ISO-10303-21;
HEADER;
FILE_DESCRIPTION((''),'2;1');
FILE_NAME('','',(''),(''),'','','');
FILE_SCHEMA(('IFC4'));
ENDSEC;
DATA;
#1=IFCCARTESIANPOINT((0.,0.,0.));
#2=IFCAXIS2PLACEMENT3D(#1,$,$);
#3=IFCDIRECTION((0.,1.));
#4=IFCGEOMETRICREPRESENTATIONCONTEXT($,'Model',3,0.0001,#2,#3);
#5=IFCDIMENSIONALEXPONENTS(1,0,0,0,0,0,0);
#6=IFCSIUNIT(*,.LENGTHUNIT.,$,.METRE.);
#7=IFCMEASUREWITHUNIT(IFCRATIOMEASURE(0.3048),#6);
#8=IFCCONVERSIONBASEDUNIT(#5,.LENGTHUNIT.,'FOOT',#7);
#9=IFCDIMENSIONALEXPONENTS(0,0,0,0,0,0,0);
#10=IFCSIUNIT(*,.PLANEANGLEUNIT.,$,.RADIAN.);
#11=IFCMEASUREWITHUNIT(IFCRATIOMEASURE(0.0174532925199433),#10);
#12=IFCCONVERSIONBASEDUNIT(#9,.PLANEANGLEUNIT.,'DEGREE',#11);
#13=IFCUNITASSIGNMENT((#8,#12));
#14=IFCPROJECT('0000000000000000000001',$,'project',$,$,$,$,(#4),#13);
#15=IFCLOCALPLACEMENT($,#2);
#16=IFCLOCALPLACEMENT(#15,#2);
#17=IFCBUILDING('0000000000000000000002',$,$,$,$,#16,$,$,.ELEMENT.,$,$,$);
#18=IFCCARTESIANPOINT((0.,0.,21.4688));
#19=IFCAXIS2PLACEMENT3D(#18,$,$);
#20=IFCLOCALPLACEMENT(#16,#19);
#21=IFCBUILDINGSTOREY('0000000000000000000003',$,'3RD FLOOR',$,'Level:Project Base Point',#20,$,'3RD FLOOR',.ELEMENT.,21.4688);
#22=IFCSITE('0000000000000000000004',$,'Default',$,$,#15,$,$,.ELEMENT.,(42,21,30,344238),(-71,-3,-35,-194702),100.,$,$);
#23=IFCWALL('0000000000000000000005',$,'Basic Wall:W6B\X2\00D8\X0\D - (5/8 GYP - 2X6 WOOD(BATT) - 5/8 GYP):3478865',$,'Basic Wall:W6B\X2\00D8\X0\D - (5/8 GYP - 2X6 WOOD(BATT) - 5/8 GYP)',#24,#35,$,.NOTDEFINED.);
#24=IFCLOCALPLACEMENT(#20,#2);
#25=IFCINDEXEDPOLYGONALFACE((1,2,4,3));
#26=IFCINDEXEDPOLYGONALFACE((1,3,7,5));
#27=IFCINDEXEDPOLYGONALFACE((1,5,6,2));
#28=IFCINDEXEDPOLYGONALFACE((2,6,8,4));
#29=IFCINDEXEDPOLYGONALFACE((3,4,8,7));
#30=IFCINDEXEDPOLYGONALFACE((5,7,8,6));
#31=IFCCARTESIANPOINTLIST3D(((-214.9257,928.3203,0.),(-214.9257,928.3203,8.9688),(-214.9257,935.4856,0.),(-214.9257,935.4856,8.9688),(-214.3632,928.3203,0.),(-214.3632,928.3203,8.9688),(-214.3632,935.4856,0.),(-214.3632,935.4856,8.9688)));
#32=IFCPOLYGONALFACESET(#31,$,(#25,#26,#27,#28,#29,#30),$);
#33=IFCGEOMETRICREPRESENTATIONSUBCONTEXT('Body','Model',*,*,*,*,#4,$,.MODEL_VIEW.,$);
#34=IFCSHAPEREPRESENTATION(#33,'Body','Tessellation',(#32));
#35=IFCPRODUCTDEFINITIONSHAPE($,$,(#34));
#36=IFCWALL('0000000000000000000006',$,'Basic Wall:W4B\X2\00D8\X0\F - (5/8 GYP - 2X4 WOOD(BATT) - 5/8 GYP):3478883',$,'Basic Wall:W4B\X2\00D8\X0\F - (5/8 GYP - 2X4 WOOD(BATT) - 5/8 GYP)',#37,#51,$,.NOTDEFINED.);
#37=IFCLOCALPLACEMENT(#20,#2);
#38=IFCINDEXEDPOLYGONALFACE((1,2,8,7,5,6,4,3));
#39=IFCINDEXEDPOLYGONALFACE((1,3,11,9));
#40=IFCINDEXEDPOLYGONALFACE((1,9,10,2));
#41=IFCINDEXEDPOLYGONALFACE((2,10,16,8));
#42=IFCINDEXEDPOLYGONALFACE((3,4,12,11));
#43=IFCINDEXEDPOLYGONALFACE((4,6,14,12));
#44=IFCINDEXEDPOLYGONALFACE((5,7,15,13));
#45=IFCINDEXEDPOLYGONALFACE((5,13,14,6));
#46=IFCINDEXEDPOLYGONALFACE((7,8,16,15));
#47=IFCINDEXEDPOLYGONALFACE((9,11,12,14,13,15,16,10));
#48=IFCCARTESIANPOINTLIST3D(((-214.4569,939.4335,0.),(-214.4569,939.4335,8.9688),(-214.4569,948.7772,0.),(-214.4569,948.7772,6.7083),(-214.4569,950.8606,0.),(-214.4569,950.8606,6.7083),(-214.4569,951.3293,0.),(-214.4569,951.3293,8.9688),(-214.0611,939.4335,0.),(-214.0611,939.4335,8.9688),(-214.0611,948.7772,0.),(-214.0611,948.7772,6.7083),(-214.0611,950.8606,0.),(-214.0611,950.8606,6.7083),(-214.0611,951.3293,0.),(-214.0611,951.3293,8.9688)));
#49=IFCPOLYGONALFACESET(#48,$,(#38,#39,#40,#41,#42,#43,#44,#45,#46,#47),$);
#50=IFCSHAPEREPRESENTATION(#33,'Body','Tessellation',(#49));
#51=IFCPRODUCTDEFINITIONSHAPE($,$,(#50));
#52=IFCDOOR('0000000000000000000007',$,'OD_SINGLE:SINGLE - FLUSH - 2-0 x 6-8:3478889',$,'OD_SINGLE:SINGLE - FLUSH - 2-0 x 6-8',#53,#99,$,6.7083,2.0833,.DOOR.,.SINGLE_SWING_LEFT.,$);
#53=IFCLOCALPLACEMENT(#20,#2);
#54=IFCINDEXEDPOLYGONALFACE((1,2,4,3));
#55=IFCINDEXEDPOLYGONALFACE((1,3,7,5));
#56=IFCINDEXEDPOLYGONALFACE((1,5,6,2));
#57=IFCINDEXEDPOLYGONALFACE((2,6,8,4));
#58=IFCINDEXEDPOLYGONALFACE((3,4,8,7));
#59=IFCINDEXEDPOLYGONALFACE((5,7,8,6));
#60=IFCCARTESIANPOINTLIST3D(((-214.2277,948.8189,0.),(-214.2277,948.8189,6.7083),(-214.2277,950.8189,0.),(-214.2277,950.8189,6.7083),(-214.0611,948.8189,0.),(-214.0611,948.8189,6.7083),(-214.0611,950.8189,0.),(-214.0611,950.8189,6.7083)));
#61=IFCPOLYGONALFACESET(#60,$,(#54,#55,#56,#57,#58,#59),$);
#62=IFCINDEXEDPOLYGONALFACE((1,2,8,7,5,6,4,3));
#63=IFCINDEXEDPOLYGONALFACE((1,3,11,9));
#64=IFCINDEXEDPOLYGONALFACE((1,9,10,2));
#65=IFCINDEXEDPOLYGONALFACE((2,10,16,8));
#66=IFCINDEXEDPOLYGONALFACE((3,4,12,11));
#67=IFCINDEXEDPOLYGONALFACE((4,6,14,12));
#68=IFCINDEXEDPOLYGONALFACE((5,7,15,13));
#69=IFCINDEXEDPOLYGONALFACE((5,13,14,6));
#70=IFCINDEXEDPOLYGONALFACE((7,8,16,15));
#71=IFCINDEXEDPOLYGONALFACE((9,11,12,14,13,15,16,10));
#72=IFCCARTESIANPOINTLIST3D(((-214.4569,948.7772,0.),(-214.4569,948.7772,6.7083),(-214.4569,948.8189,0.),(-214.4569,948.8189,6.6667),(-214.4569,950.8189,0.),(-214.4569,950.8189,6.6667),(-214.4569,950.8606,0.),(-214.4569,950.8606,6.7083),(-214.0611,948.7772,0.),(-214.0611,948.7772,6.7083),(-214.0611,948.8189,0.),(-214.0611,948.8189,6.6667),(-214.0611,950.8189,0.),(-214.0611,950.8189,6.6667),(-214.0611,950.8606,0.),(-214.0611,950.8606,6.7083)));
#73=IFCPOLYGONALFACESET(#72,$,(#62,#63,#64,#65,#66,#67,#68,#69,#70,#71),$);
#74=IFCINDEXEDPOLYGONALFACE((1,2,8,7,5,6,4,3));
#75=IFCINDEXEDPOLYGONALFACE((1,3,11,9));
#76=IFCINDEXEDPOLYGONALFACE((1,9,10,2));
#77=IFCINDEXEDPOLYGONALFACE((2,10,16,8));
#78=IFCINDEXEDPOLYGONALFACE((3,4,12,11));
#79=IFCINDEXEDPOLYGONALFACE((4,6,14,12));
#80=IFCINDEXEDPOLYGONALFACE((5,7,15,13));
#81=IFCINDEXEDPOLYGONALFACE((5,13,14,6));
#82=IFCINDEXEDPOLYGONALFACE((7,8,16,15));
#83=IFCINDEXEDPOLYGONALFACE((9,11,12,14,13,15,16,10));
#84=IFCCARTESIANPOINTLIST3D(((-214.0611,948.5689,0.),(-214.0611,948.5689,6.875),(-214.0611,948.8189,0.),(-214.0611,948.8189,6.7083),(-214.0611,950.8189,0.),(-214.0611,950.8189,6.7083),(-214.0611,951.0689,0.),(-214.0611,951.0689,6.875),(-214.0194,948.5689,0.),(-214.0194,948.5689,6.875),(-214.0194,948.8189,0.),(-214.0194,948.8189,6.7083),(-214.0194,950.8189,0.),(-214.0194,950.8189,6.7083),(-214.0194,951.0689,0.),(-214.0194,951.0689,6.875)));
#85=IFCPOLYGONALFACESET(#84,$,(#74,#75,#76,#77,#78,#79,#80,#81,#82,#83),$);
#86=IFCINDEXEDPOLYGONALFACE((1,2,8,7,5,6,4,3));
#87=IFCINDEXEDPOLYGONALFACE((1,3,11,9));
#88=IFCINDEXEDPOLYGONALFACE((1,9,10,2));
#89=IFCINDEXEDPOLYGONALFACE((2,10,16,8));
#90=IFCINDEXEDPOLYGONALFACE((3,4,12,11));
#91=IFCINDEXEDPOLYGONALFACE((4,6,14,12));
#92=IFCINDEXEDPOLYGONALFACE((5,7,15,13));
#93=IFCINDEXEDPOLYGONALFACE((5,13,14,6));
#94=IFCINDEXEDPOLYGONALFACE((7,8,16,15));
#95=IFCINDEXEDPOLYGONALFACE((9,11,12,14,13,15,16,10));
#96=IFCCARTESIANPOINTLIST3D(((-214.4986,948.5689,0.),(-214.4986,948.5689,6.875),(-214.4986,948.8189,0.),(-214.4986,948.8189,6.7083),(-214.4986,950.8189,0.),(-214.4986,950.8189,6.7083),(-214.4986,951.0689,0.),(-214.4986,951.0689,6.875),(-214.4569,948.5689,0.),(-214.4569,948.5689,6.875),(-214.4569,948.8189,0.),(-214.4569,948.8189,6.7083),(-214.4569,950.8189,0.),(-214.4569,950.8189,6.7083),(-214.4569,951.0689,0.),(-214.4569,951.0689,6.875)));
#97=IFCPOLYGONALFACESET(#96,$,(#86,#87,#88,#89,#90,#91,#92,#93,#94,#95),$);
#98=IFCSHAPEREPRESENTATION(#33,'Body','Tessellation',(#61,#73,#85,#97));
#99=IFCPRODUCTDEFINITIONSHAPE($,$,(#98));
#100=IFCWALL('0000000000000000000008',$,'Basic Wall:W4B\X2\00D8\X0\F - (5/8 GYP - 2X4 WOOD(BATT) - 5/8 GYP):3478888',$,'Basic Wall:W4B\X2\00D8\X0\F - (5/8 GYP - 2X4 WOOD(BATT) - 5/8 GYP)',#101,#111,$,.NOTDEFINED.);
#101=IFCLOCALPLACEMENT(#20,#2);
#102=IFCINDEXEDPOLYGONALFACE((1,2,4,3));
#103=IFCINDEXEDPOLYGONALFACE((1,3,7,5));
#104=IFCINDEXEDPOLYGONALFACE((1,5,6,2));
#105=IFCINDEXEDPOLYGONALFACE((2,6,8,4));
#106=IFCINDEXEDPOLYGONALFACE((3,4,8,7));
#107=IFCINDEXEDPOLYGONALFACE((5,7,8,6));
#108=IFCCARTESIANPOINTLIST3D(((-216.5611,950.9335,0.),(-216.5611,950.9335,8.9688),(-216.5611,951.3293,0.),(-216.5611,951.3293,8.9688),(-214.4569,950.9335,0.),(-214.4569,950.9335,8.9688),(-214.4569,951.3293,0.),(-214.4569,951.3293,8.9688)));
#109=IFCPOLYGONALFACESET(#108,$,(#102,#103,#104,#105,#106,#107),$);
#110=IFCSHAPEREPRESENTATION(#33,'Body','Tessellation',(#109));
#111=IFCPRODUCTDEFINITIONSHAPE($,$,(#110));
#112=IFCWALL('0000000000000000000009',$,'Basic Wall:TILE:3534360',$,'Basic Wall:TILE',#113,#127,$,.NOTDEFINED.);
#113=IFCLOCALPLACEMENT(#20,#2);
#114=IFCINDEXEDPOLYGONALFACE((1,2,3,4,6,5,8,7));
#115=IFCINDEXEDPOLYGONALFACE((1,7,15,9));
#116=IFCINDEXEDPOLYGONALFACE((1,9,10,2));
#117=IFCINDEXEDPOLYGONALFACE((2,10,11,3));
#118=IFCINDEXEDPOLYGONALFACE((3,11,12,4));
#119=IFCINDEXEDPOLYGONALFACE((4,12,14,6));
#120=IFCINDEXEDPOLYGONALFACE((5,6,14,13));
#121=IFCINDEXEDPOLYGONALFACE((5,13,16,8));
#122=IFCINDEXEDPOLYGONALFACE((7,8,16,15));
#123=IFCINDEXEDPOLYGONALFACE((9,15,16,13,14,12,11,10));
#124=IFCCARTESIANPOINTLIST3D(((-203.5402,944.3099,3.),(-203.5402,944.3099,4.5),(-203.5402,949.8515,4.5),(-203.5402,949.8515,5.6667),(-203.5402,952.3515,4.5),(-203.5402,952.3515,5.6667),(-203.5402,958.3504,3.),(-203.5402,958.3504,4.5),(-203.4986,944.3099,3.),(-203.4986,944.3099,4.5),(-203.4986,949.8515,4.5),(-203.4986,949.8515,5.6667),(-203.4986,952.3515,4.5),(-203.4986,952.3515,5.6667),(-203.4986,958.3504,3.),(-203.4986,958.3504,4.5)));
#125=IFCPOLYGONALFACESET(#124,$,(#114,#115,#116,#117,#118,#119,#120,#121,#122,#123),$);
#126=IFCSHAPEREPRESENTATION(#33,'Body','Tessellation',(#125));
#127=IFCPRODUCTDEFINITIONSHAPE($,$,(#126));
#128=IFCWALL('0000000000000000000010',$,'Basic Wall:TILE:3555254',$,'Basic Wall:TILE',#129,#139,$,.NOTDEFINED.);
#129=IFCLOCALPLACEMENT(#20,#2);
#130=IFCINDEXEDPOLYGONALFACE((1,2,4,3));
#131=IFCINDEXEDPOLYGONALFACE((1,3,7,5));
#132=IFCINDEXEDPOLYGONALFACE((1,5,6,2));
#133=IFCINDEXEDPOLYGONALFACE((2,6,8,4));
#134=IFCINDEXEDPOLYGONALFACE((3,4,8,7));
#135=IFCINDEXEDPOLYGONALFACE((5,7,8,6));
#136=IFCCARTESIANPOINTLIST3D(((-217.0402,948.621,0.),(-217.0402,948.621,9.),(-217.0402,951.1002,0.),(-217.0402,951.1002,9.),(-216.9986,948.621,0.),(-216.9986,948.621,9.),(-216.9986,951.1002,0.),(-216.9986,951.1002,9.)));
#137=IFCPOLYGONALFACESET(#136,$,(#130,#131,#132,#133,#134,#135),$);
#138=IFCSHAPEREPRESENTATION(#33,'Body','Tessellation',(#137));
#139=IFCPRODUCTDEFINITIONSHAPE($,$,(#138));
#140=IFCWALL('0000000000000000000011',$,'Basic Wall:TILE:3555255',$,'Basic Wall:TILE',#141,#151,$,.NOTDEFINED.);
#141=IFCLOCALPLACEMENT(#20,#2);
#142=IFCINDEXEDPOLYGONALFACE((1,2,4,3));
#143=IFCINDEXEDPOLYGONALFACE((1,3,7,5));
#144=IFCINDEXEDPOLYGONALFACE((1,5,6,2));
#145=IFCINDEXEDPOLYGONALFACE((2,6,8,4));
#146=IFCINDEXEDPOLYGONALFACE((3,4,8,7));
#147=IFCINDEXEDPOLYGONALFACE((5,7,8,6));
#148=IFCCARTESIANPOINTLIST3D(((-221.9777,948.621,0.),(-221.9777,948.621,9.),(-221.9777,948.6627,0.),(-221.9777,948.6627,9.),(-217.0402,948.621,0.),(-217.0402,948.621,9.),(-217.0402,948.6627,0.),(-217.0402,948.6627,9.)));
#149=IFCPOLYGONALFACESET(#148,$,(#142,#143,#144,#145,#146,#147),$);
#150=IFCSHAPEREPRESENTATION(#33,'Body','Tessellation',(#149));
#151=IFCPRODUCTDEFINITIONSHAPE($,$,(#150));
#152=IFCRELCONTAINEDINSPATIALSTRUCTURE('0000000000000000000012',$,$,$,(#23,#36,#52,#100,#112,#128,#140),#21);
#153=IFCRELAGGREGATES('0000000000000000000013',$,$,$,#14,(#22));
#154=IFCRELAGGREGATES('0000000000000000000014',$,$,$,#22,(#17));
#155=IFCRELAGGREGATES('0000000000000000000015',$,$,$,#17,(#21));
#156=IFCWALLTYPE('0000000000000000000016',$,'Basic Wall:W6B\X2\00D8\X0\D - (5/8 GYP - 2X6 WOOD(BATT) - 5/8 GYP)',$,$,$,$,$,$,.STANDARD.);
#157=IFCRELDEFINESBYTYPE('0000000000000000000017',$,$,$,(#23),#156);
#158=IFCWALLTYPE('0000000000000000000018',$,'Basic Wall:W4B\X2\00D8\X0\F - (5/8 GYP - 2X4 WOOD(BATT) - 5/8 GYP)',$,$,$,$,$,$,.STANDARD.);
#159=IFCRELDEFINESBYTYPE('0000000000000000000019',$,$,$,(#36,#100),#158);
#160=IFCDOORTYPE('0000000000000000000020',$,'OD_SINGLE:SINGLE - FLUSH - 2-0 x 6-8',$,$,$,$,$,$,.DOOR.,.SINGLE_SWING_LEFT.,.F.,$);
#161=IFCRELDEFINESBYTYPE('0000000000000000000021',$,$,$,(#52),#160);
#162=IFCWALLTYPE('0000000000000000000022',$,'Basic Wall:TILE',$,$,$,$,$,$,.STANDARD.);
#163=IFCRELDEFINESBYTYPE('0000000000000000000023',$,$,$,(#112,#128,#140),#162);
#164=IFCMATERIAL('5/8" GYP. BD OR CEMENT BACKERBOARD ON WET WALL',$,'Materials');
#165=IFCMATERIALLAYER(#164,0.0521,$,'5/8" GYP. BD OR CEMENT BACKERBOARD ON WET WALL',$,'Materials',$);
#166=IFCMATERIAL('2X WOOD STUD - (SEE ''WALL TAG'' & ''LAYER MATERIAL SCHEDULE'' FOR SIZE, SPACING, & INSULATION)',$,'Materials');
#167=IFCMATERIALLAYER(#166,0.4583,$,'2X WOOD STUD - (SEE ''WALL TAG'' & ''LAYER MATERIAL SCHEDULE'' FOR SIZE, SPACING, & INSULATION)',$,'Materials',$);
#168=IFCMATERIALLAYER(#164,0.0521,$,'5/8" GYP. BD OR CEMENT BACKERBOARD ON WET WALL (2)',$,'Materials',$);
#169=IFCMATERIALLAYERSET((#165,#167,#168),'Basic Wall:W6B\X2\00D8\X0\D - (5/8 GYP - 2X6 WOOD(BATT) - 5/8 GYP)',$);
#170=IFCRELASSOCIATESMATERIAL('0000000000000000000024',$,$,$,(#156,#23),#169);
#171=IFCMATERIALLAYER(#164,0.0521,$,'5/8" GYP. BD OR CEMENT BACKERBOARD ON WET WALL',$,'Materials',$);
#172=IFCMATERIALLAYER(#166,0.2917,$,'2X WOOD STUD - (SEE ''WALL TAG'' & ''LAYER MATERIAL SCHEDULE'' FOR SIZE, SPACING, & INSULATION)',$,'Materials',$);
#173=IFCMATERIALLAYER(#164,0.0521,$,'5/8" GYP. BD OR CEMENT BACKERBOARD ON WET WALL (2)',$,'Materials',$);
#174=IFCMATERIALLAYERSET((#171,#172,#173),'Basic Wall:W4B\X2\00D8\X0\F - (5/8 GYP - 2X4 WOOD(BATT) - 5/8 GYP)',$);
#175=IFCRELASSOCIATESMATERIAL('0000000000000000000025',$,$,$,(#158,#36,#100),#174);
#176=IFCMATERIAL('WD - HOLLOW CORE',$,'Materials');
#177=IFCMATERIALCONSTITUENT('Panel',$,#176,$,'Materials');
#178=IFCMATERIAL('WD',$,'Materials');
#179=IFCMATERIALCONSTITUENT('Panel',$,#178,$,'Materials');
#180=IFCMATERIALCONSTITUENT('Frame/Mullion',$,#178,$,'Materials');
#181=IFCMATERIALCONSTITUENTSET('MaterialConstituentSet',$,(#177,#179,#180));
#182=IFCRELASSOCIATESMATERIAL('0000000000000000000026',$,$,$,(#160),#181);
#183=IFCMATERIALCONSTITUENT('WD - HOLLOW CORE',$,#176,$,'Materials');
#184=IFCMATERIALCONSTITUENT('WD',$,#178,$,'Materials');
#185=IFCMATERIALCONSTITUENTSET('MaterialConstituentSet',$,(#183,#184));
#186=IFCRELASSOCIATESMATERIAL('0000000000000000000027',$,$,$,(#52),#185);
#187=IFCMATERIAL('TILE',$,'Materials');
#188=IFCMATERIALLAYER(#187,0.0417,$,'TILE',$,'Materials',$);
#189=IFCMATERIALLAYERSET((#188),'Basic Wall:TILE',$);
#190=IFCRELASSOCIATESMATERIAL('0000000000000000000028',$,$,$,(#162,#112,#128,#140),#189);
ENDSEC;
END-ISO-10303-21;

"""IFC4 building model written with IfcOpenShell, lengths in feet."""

from ifc_helpers import new_model, entity, si_unit, converted_unit, direction, frame, frame_2d, origin, origin_2d_with_axis, place, context, subcontext, project, spatial, polyline, rectangle, outline, extrude, source, transform, mapped, material, layer, layer_set, layer_usage, constituent, constituent_set, type_object, type_shapes, element, fill, save


model = new_model("IFC4")

# Units and contexts
model_context = context("Model", 3, precision=0.0001, world=origin(), true_north=direction((0.0, 1.0)))
body_context = subcontext(model_context, "Body", "Model", "MODEL_VIEW")
ifc_project = project(units=[converted_unit("LENGTHUNIT", "FOOT", entity("IfcRatioMeasure", 0.3048), si_unit("LENGTHUNIT", "METRE"), dimensions=[1, 0, 0, 0, 0, 0, 0]), converted_unit("PLANEANGLEUNIT", "DEGREE", entity("IfcRatioMeasure", 0.0174532925199433), si_unit("PLANEANGLEUNIT", "RADIAN"), dimensions=[0, 0, 0, 0, 0, 0, 0])], contexts=[model_context])

# Site, building, storey
site_placement = place(None, origin())
site = spatial("IfcSite", under=ifc_project, at=site_placement, Name="Default", CompositionType="ELEMENT", RefLatitude=(42, 21, 30, 344238), RefLongitude=(-71, -3, -35, -194702), RefElevation=100.0)
building_placement = place(site_placement, origin())
building = spatial("IfcBuilding", under=site, at=building_placement, CompositionType="ELEMENT")
storey_placement = place(building_placement, frame((0.0, 0.0, 21.4688)))
storey = spatial("IfcBuildingStorey", under=building, at=storey_placement, Name="3RD FLOOR", ObjectType="Level:Project Base Point", LongName="3RD FLOOR", CompositionType="ELEMENT", Elevation=21.4688)

# Wall
ifc_material_1 = material(Name="5/8\" GYP. BD OR CEMENT BACKERBOARD ON WET WALL", Category="Materials")
ifc_layer_1 = layer(ifc_material_1, 0.0521, Name="5/8\" GYP. BD OR CEMENT BACKERBOARD ON WET WALL", Category="Materials")
ifc_material_2 = material(Name="2X WOOD STUD - (SEE 'WALL TAG' & 'LAYER MATERIAL SCHEDULE' FOR SIZE, SPACING, & INSULATION)", Category="Materials")
ifc_layer_2 = layer(ifc_material_2, 0.4583, Name="2X WOOD STUD - (SEE 'WALL TAG' & 'LAYER MATERIAL SCHEDULE' FOR SIZE, SPACING, & INSULATION)", Category="Materials")
ifc_layer_3 = layer(ifc_material_1, 0.0521, Name="5/8\" GYP. BD OR CEMENT BACKERBOARD ON WET WALL (2)", Category="Materials")
ifc_layer_set_1 = layer_set([ifc_layer_1, ifc_layer_2, ifc_layer_3], Name="Basic Wall:W6BØD - (5/8 GYP - 2X6 WOOD(BATT) - 5/8 GYP)")
ifc_layer_usage_1 = layer_usage(ifc_layer_set_1, "AXIS2", "POSITIVE", -0.2812)
wall_type_1 = type_object("IfcWallType", Name="Basic Wall:W6BØD - (5/8 GYP - 2X6 WOOD(BATT) - 5/8 GYP)", PredefinedType="STANDARD", material=ifc_layer_set_1)
wall_1_placement = place(storey_placement, frame((-214.6444, 928.3203, 0.0), z_axis=(0.0, 0.0, 1.0), x_axis=(0.0, 1.0, 0.0)))
element("IfcWall", 1, at=wall_1_placement, inside=storey, type_object=wall_type_1, material=ifc_layer_usage_1, Name="Basic Wall:W6BØD - (5/8 GYP - 2X6 WOOD(BATT) - 5/8 GYP):3478865", ObjectType="Basic Wall:W6BØD - (5/8 GYP - 2X6 WOOD(BATT) - 5/8 GYP)", PredefinedType="NOTDEFINED", context=body_context, shape_type="SweptSolid", body=[
    extrude(rectangle(XDim=7.1653, YDim=0.5625, at=frame_2d((3.5826, 0.0), x_axis=(-1.0, 0.0))), origin(), (0.0, 0.0, 1.0), 8.9688),
])

# Wall, opening, door
ifc_layer_4 = layer(ifc_material_1, 0.0521, Name="5/8\" GYP. BD OR CEMENT BACKERBOARD ON WET WALL", Category="Materials")
ifc_layer_5 = layer(ifc_material_2, 0.2917, Name="2X WOOD STUD - (SEE 'WALL TAG' & 'LAYER MATERIAL SCHEDULE' FOR SIZE, SPACING, & INSULATION)", Category="Materials")
ifc_layer_6 = layer(ifc_material_1, 0.0521, Name="5/8\" GYP. BD OR CEMENT BACKERBOARD ON WET WALL (2)", Category="Materials")
ifc_layer_set_2 = layer_set([ifc_layer_4, ifc_layer_5, ifc_layer_6], Name="Basic Wall:W4BØF - (5/8 GYP - 2X4 WOOD(BATT) - 5/8 GYP)")
wall_type_2 = type_object("IfcWallType", Name="Basic Wall:W4BØF - (5/8 GYP - 2X4 WOOD(BATT) - 5/8 GYP)", PredefinedType="STANDARD", material=ifc_layer_set_2)
ifc_material_3 = material(Name="WD - HOLLOW CORE", Category="Materials")
ifc_material_4 = material(Name="WD", Category="Materials")
ifc_layer_usage_2 = layer_usage(ifc_layer_set_2, "AXIS2", "POSITIVE", -0.1979)
wall_2_placement = place(storey_placement, frame((-214.259, 939.4335, 0.0), z_axis=(0.0, 0.0, 1.0), x_axis=(0.0, 1.0, 0.0)))
wall_2 = element("IfcWall", 2, at=wall_2_placement, inside=storey, type_object=wall_type_2, material=ifc_layer_usage_2, Name="Basic Wall:W4BØF - (5/8 GYP - 2X4 WOOD(BATT) - 5/8 GYP):3478883", ObjectType="Basic Wall:W4BØF - (5/8 GYP - 2X4 WOOD(BATT) - 5/8 GYP)", PredefinedType="NOTDEFINED", context=body_context, shape_type="SweptSolid", body=[
    extrude(rectangle(XDim=11.8958, YDim=0.3958, at=frame_2d((5.9479, 0.0), x_axis=(-1.0, 0.0))), origin(), (0.0, 0.0, 1.0), 8.9688),
])
opening_1_placement = place(wall_2_placement, frame((11.4271, 0.1979, 0.0)))
opening_1 = element("IfcOpeningElement", 3, at=opening_1_placement, cuts=wall_2, PredefinedType="OPENING", context=body_context, shape_type="SweptSolid", body=[
    extrude(rectangle(XDim=2.0833, YDim=6.7083, at=frame_2d((3.3542, 1.0417), x_axis=(0.0, -1.0))), frame((0.0, 0.0, 0.0), z_axis=(0.0, -1.0, 0.0), x_axis=(0.0, 0.0, 1.0)), (0.0, 0.0, 1.0), 0.3958),
])
ifc_constituent_1 = constituent(ifc_material_3, Name="WD - HOLLOW CORE", Category="Materials")
ifc_constituent_2 = constituent(ifc_material_4, Name="WD", Category="Materials")
ifc_constituent_set_1 = constituent_set(constituents=[ifc_constituent_1, ifc_constituent_2], Name="MaterialConstituentSet")
ifc_constituent_3 = constituent(ifc_material_3, Name="Panel", Category="Materials")
ifc_constituent_4 = constituent(ifc_material_4, Name="Panel", Category="Materials")
ifc_constituent_5 = constituent(ifc_material_4, Name="Frame/Mullion", Category="Materials")
ifc_constituent_set_2 = constituent_set(constituents=[ifc_constituent_3, ifc_constituent_4, ifc_constituent_5], Name="MaterialConstituentSet")
door_type_1 = type_object("IfcDoorType", Name="OD_SINGLE:SINGLE - FLUSH - 2-0 x 6-8", OperationType="SINGLE_SWING_LEFT", ParameterTakesPrecedence=False, PredefinedType="DOOR", material=ifc_constituent_set_2)
shared_shape_1 = source(origin(), body_context, "Body", "SweptSolid", [
    extrude(rectangle(XDim=2.0, YDim=0.1667, at=origin_2d_with_axis()), frame((1.0417, 0.3125, 0.0)), (0.0, 0.0, 1.0), 6.7083),
    extrude(outline(polyline([(-3.3646, -1.0417), (3.3438, -1.0417), (3.3438, -1.0), (-3.3229, -1.0), (-3.3229, 1.0), (3.3438, 1.0), (3.3438, 1.0417), (-3.3646, 1.0417), (-3.3646, -1.0417)])), frame((1.0417, 0.3958, 3.3438), z_axis=(0.0, -1.0, 0.0), x_axis=(0.0, 0.0, -1.0)), (0.0, 0.0, 1.0), 0.3958),
    extrude(outline(polyline([(-1.25, -3.4792), (1.25, -3.4792), (1.25, 3.3958), (1.0, 3.3958), (1.0, -3.3125), (-1.0, -3.3125), (-1.0, 3.3958), (-1.25, 3.3958), (-1.25, -3.4792)])), frame((1.0417, 0.4375, 3.3958), z_axis=(0.0, -1.0, 0.0), x_axis=(-1.0, 0.0, 0.0)), (0.0, 0.0, 1.0), 0.0417),
    extrude(outline(polyline([(-3.4792, -1.25), (3.3958, -1.25), (3.3958, -1.0), (-3.3125, -1.0), (-3.3125, 1.0), (3.3958, 1.0), (3.3958, 1.25), (-3.4792, 1.25), (-3.4792, -1.25)])), frame((1.0417, 0.0, 3.3958), z_axis=(0.0, -1.0, 0.0), x_axis=(0.0, 0.0, -1.0)), (0.0, 0.0, 1.0), 0.0417),
])
type_shapes(door_type_1, [shared_shape_1])
door_1_placement = place(opening_1_placement, frame((0.0, 0.0, 0.0), z_axis=(0.0, 0.0, 1.0), x_axis=(-1.0, 0.0, 0.0)))
door_1 = element("IfcDoor", 4, at=door_1_placement, inside=storey, type_object=door_type_1, material=ifc_constituent_set_1, Name="OD_SINGLE:SINGLE - FLUSH - 2-0 x 6-8:3478889", ObjectType="OD_SINGLE:SINGLE - FLUSH - 2-0 x 6-8", OperationType="SINGLE_SWING_LEFT", OverallHeight=6.7083, OverallWidth=2.0833, PredefinedType="DOOR", context=body_context, shape_type="MappedRepresentation", body=[
    mapped(shared_shape_1, transform((0.0, 0.0, 0.0), scale=1.0)),
])
fill(opening_1, door_1)

# Wall
ifc_layer_usage_3 = layer_usage(ifc_layer_set_2, "AXIS2", "NEGATIVE", 0.1979)
wall_3_placement = place(storey_placement, frame((-216.5611, 951.1314, 0.0)))
element("IfcWall", 5, at=wall_3_placement, inside=storey, type_object=wall_type_2, material=ifc_layer_usage_3, Name="Basic Wall:W4BØF - (5/8 GYP - 2X4 WOOD(BATT) - 5/8 GYP):3478888", ObjectType="Basic Wall:W4BØF - (5/8 GYP - 2X4 WOOD(BATT) - 5/8 GYP)", PredefinedType="NOTDEFINED", context=body_context, shape_type="SweptSolid", body=[
    extrude(rectangle(XDim=2.1042, YDim=0.3958, at=frame_2d((1.0521, 0.0), x_axis=(-1.0, 0.0))), origin(), (0.0, 0.0, 1.0), 8.9688),
])

# Wall, openings
ifc_material_5 = material(Name="TILE", Category="Materials")
ifc_layer_7 = layer(ifc_material_5, 0.0417, Name="TILE", Category="Materials")
ifc_layer_set_3 = layer_set([ifc_layer_7], Name="Basic Wall:TILE")
ifc_layer_usage_4 = layer_usage(ifc_layer_set_3, "AXIS2", "NEGATIVE", 0.0208)
wall_type_3 = type_object("IfcWallType", Name="Basic Wall:TILE", PredefinedType="STANDARD", material=ifc_layer_set_3)
wall_4_placement = place(storey_placement, frame((-203.5194, 958.3504, 3.0), z_axis=(0.0, 0.0, 1.0), x_axis=(0.0, -1.0, 0.0)))
wall_4 = element("IfcWall", 6, at=wall_4_placement, inside=storey, type_object=wall_type_3, material=ifc_layer_usage_4, Name="Basic Wall:TILE:3534360", ObjectType="Basic Wall:TILE", PredefinedType="NOTDEFINED", context=body_context, shape_type="SweptSolid", body=[
    extrude(rectangle(XDim=14.0406, YDim=0.0417, at=frame_2d((7.0203, 0.0), x_axis=(-1.0, 0.0))), origin(), (0.0, 0.0, 1.0), 2.6667),
])
opening_2_placement = place(wall_4_placement, origin())
element("IfcOpeningElement", 7, at=opening_2_placement, cuts=wall_4, PredefinedType="OPENING", context=body_context, shape_type="SweptSolid", body=[
    extrude(rectangle(XDim=1.1667, YDim=5.5417, at=origin_2d_with_axis()), frame((11.2697, 0.0208, 2.0833), z_axis=(0.0, -1.0, 0.0), x_axis=(0.0, 0.0, 1.0)), (0.0, 0.0, 1.0), 0.0417),
])
opening_3_placement = place(wall_4_placement, origin())
element("IfcOpeningElement", 8, at=opening_3_placement, cuts=wall_4, PredefinedType="OPENING", context=body_context, shape_type="SweptSolid", body=[
    extrude(rectangle(XDim=1.1667, YDim=5.9989, at=frame_2d((0.0, 0.0), x_axis=(0.0, 1.0))), frame((2.9994, 0.0208, 2.0833), z_axis=(0.0, -1.0, 0.0), x_axis=(-1.0, 0.0, 0.0)), (0.0, 0.0, 1.0), 0.0417),
])

# Walls
ifc_layer_usage_5 = layer_usage(ifc_layer_set_3, "AXIS2", "NEGATIVE", 0.0208)
wall_5_placement = place(storey_placement, frame((-217.0194, 951.1002, 0.0), z_axis=(0.0, 0.0, 1.0), x_axis=(0.0, -1.0, 0.0)))
element("IfcWall", 9, at=wall_5_placement, inside=storey, type_object=wall_type_3, material=ifc_layer_usage_5, Name="Basic Wall:TILE:3555254", ObjectType="Basic Wall:TILE", PredefinedType="NOTDEFINED", context=body_context, shape_type="SweptSolid", body=[
    extrude(rectangle(XDim=2.4792, YDim=0.0417, at=frame_2d((1.2396, 0.0), x_axis=(-1.0, 0.0))), origin(), (0.0, 0.0, 1.0), 9.0),
])
ifc_layer_usage_6 = layer_usage(ifc_layer_set_3, "AXIS2", "NEGATIVE", 0.0208)
wall_6_placement = place(storey_placement, frame((-217.0402, 948.6418, 0.0), z_axis=(0.0, 0.0, 1.0), x_axis=(-1.0, 0.0, 0.0)))
element("IfcWall", 10, at=wall_6_placement, inside=storey, type_object=wall_type_3, material=ifc_layer_usage_6, Name="Basic Wall:TILE:3555255", ObjectType="Basic Wall:TILE", PredefinedType="NOTDEFINED", context=body_context, shape_type="SweptSolid", body=[
    extrude(rectangle(XDim=4.9375, YDim=0.0417, at=frame_2d((2.4688, 0.0), x_axis=(-1.0, 0.0))), origin(), (0.0, 0.0, 1.0), 9.0),
])

save(model, "model.ifc")
